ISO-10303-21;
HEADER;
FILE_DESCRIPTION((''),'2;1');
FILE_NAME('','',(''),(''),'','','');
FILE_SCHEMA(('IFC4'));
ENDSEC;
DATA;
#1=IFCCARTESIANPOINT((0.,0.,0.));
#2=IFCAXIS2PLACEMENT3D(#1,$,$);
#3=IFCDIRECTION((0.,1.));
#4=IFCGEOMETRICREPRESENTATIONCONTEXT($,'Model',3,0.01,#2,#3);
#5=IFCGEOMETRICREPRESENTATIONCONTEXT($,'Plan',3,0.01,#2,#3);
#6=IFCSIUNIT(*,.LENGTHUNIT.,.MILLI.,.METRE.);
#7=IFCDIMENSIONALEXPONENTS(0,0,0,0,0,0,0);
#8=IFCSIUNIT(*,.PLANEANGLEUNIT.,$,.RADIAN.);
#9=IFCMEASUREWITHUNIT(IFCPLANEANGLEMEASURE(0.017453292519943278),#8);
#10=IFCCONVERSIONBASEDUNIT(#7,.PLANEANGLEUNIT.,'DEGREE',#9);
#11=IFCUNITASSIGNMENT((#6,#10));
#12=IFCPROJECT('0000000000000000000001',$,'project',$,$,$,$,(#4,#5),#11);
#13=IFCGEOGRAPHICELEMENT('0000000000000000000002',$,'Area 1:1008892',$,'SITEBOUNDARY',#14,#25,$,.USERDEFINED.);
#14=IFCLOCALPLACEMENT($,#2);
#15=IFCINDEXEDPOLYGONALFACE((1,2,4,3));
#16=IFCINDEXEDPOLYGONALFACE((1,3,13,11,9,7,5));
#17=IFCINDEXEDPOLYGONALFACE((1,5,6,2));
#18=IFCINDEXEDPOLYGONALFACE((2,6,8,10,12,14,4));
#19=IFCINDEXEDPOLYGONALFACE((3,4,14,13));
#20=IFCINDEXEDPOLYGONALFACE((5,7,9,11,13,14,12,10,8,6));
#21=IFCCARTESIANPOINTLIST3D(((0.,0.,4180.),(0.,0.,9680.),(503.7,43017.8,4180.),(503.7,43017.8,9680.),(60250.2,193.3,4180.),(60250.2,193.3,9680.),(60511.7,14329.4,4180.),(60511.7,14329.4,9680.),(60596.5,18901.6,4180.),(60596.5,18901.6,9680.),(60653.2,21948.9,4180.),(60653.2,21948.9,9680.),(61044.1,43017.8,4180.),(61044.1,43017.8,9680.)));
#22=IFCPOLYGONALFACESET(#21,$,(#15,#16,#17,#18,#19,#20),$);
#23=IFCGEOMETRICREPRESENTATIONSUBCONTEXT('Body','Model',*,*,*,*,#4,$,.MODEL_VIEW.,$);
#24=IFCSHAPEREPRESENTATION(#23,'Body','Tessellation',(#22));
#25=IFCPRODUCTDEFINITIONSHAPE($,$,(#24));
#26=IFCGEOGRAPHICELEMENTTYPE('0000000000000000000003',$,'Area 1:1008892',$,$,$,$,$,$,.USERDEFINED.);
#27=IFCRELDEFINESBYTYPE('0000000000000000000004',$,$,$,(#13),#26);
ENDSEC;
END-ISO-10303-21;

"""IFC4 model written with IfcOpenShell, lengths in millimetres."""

from ifc_helpers import new_model, entity, si_unit, converted_unit, direction, frame, origin, place, context, subcontext, project, indexed_curve, outline, extrude, type_object, element, save


model = new_model("IFC4")

# Units and contexts
model_context = context("Model", 3, precision=0.01, world=origin(), true_north=direction((0.0, 1.0)))
plan_context = context("Plan", 3, precision=0.01, world=origin(), true_north=direction((0.0, 1.0)))
body_context = subcontext(model_context, "Body", "Model", "MODEL_VIEW")
ifc_project = project(units=[si_unit("LENGTHUNIT", "METRE", prefix="MILLI"), converted_unit("PLANEANGLEUNIT", "DEGREE", entity("IfcPlaneAngleMeasure", 0.017453292519943278), si_unit("PLANEANGLEUNIT", "RADIAN"), dimensions=[0, 0, 0, 0, 0, 0, 0])], contexts=[model_context, plan_context])

# Geographic element
geographic_element_type = type_object("IfcGeographicElementType", Name="Area 1:1008892", PredefinedType="USERDEFINED")
placement_1 = place(None, frame((0.0, 0.0, -104180.0)))
placement_2 = place(placement_1, origin())
placement_3 = place(placement_2, frame((0.0, 0.0, 108360.0)))
geographic_element_placement = place(placement_3, origin())
element("IfcGeographicElement", 1, at=geographic_element_placement, type_object=geographic_element_type, Name="Area 1:1008892", ObjectType="SITEBOUNDARY", PredefinedType="USERDEFINED", context=body_context, shape_type="SweptSolid", body=[
    extrude(outline(indexed_curve([(61044.1, 43017.8), (503.7, 43017.8), (0.0, 0.0), (60250.2, 193.3), (60511.7, 14329.4), (60596.5, 18901.6), (60653.2, 21948.9), (61044.1, 43017.8)], self_intersect=False)), origin(), (0.0, 0.0, 1.0), 5500.0),
])

save(model, "model.ifc")
